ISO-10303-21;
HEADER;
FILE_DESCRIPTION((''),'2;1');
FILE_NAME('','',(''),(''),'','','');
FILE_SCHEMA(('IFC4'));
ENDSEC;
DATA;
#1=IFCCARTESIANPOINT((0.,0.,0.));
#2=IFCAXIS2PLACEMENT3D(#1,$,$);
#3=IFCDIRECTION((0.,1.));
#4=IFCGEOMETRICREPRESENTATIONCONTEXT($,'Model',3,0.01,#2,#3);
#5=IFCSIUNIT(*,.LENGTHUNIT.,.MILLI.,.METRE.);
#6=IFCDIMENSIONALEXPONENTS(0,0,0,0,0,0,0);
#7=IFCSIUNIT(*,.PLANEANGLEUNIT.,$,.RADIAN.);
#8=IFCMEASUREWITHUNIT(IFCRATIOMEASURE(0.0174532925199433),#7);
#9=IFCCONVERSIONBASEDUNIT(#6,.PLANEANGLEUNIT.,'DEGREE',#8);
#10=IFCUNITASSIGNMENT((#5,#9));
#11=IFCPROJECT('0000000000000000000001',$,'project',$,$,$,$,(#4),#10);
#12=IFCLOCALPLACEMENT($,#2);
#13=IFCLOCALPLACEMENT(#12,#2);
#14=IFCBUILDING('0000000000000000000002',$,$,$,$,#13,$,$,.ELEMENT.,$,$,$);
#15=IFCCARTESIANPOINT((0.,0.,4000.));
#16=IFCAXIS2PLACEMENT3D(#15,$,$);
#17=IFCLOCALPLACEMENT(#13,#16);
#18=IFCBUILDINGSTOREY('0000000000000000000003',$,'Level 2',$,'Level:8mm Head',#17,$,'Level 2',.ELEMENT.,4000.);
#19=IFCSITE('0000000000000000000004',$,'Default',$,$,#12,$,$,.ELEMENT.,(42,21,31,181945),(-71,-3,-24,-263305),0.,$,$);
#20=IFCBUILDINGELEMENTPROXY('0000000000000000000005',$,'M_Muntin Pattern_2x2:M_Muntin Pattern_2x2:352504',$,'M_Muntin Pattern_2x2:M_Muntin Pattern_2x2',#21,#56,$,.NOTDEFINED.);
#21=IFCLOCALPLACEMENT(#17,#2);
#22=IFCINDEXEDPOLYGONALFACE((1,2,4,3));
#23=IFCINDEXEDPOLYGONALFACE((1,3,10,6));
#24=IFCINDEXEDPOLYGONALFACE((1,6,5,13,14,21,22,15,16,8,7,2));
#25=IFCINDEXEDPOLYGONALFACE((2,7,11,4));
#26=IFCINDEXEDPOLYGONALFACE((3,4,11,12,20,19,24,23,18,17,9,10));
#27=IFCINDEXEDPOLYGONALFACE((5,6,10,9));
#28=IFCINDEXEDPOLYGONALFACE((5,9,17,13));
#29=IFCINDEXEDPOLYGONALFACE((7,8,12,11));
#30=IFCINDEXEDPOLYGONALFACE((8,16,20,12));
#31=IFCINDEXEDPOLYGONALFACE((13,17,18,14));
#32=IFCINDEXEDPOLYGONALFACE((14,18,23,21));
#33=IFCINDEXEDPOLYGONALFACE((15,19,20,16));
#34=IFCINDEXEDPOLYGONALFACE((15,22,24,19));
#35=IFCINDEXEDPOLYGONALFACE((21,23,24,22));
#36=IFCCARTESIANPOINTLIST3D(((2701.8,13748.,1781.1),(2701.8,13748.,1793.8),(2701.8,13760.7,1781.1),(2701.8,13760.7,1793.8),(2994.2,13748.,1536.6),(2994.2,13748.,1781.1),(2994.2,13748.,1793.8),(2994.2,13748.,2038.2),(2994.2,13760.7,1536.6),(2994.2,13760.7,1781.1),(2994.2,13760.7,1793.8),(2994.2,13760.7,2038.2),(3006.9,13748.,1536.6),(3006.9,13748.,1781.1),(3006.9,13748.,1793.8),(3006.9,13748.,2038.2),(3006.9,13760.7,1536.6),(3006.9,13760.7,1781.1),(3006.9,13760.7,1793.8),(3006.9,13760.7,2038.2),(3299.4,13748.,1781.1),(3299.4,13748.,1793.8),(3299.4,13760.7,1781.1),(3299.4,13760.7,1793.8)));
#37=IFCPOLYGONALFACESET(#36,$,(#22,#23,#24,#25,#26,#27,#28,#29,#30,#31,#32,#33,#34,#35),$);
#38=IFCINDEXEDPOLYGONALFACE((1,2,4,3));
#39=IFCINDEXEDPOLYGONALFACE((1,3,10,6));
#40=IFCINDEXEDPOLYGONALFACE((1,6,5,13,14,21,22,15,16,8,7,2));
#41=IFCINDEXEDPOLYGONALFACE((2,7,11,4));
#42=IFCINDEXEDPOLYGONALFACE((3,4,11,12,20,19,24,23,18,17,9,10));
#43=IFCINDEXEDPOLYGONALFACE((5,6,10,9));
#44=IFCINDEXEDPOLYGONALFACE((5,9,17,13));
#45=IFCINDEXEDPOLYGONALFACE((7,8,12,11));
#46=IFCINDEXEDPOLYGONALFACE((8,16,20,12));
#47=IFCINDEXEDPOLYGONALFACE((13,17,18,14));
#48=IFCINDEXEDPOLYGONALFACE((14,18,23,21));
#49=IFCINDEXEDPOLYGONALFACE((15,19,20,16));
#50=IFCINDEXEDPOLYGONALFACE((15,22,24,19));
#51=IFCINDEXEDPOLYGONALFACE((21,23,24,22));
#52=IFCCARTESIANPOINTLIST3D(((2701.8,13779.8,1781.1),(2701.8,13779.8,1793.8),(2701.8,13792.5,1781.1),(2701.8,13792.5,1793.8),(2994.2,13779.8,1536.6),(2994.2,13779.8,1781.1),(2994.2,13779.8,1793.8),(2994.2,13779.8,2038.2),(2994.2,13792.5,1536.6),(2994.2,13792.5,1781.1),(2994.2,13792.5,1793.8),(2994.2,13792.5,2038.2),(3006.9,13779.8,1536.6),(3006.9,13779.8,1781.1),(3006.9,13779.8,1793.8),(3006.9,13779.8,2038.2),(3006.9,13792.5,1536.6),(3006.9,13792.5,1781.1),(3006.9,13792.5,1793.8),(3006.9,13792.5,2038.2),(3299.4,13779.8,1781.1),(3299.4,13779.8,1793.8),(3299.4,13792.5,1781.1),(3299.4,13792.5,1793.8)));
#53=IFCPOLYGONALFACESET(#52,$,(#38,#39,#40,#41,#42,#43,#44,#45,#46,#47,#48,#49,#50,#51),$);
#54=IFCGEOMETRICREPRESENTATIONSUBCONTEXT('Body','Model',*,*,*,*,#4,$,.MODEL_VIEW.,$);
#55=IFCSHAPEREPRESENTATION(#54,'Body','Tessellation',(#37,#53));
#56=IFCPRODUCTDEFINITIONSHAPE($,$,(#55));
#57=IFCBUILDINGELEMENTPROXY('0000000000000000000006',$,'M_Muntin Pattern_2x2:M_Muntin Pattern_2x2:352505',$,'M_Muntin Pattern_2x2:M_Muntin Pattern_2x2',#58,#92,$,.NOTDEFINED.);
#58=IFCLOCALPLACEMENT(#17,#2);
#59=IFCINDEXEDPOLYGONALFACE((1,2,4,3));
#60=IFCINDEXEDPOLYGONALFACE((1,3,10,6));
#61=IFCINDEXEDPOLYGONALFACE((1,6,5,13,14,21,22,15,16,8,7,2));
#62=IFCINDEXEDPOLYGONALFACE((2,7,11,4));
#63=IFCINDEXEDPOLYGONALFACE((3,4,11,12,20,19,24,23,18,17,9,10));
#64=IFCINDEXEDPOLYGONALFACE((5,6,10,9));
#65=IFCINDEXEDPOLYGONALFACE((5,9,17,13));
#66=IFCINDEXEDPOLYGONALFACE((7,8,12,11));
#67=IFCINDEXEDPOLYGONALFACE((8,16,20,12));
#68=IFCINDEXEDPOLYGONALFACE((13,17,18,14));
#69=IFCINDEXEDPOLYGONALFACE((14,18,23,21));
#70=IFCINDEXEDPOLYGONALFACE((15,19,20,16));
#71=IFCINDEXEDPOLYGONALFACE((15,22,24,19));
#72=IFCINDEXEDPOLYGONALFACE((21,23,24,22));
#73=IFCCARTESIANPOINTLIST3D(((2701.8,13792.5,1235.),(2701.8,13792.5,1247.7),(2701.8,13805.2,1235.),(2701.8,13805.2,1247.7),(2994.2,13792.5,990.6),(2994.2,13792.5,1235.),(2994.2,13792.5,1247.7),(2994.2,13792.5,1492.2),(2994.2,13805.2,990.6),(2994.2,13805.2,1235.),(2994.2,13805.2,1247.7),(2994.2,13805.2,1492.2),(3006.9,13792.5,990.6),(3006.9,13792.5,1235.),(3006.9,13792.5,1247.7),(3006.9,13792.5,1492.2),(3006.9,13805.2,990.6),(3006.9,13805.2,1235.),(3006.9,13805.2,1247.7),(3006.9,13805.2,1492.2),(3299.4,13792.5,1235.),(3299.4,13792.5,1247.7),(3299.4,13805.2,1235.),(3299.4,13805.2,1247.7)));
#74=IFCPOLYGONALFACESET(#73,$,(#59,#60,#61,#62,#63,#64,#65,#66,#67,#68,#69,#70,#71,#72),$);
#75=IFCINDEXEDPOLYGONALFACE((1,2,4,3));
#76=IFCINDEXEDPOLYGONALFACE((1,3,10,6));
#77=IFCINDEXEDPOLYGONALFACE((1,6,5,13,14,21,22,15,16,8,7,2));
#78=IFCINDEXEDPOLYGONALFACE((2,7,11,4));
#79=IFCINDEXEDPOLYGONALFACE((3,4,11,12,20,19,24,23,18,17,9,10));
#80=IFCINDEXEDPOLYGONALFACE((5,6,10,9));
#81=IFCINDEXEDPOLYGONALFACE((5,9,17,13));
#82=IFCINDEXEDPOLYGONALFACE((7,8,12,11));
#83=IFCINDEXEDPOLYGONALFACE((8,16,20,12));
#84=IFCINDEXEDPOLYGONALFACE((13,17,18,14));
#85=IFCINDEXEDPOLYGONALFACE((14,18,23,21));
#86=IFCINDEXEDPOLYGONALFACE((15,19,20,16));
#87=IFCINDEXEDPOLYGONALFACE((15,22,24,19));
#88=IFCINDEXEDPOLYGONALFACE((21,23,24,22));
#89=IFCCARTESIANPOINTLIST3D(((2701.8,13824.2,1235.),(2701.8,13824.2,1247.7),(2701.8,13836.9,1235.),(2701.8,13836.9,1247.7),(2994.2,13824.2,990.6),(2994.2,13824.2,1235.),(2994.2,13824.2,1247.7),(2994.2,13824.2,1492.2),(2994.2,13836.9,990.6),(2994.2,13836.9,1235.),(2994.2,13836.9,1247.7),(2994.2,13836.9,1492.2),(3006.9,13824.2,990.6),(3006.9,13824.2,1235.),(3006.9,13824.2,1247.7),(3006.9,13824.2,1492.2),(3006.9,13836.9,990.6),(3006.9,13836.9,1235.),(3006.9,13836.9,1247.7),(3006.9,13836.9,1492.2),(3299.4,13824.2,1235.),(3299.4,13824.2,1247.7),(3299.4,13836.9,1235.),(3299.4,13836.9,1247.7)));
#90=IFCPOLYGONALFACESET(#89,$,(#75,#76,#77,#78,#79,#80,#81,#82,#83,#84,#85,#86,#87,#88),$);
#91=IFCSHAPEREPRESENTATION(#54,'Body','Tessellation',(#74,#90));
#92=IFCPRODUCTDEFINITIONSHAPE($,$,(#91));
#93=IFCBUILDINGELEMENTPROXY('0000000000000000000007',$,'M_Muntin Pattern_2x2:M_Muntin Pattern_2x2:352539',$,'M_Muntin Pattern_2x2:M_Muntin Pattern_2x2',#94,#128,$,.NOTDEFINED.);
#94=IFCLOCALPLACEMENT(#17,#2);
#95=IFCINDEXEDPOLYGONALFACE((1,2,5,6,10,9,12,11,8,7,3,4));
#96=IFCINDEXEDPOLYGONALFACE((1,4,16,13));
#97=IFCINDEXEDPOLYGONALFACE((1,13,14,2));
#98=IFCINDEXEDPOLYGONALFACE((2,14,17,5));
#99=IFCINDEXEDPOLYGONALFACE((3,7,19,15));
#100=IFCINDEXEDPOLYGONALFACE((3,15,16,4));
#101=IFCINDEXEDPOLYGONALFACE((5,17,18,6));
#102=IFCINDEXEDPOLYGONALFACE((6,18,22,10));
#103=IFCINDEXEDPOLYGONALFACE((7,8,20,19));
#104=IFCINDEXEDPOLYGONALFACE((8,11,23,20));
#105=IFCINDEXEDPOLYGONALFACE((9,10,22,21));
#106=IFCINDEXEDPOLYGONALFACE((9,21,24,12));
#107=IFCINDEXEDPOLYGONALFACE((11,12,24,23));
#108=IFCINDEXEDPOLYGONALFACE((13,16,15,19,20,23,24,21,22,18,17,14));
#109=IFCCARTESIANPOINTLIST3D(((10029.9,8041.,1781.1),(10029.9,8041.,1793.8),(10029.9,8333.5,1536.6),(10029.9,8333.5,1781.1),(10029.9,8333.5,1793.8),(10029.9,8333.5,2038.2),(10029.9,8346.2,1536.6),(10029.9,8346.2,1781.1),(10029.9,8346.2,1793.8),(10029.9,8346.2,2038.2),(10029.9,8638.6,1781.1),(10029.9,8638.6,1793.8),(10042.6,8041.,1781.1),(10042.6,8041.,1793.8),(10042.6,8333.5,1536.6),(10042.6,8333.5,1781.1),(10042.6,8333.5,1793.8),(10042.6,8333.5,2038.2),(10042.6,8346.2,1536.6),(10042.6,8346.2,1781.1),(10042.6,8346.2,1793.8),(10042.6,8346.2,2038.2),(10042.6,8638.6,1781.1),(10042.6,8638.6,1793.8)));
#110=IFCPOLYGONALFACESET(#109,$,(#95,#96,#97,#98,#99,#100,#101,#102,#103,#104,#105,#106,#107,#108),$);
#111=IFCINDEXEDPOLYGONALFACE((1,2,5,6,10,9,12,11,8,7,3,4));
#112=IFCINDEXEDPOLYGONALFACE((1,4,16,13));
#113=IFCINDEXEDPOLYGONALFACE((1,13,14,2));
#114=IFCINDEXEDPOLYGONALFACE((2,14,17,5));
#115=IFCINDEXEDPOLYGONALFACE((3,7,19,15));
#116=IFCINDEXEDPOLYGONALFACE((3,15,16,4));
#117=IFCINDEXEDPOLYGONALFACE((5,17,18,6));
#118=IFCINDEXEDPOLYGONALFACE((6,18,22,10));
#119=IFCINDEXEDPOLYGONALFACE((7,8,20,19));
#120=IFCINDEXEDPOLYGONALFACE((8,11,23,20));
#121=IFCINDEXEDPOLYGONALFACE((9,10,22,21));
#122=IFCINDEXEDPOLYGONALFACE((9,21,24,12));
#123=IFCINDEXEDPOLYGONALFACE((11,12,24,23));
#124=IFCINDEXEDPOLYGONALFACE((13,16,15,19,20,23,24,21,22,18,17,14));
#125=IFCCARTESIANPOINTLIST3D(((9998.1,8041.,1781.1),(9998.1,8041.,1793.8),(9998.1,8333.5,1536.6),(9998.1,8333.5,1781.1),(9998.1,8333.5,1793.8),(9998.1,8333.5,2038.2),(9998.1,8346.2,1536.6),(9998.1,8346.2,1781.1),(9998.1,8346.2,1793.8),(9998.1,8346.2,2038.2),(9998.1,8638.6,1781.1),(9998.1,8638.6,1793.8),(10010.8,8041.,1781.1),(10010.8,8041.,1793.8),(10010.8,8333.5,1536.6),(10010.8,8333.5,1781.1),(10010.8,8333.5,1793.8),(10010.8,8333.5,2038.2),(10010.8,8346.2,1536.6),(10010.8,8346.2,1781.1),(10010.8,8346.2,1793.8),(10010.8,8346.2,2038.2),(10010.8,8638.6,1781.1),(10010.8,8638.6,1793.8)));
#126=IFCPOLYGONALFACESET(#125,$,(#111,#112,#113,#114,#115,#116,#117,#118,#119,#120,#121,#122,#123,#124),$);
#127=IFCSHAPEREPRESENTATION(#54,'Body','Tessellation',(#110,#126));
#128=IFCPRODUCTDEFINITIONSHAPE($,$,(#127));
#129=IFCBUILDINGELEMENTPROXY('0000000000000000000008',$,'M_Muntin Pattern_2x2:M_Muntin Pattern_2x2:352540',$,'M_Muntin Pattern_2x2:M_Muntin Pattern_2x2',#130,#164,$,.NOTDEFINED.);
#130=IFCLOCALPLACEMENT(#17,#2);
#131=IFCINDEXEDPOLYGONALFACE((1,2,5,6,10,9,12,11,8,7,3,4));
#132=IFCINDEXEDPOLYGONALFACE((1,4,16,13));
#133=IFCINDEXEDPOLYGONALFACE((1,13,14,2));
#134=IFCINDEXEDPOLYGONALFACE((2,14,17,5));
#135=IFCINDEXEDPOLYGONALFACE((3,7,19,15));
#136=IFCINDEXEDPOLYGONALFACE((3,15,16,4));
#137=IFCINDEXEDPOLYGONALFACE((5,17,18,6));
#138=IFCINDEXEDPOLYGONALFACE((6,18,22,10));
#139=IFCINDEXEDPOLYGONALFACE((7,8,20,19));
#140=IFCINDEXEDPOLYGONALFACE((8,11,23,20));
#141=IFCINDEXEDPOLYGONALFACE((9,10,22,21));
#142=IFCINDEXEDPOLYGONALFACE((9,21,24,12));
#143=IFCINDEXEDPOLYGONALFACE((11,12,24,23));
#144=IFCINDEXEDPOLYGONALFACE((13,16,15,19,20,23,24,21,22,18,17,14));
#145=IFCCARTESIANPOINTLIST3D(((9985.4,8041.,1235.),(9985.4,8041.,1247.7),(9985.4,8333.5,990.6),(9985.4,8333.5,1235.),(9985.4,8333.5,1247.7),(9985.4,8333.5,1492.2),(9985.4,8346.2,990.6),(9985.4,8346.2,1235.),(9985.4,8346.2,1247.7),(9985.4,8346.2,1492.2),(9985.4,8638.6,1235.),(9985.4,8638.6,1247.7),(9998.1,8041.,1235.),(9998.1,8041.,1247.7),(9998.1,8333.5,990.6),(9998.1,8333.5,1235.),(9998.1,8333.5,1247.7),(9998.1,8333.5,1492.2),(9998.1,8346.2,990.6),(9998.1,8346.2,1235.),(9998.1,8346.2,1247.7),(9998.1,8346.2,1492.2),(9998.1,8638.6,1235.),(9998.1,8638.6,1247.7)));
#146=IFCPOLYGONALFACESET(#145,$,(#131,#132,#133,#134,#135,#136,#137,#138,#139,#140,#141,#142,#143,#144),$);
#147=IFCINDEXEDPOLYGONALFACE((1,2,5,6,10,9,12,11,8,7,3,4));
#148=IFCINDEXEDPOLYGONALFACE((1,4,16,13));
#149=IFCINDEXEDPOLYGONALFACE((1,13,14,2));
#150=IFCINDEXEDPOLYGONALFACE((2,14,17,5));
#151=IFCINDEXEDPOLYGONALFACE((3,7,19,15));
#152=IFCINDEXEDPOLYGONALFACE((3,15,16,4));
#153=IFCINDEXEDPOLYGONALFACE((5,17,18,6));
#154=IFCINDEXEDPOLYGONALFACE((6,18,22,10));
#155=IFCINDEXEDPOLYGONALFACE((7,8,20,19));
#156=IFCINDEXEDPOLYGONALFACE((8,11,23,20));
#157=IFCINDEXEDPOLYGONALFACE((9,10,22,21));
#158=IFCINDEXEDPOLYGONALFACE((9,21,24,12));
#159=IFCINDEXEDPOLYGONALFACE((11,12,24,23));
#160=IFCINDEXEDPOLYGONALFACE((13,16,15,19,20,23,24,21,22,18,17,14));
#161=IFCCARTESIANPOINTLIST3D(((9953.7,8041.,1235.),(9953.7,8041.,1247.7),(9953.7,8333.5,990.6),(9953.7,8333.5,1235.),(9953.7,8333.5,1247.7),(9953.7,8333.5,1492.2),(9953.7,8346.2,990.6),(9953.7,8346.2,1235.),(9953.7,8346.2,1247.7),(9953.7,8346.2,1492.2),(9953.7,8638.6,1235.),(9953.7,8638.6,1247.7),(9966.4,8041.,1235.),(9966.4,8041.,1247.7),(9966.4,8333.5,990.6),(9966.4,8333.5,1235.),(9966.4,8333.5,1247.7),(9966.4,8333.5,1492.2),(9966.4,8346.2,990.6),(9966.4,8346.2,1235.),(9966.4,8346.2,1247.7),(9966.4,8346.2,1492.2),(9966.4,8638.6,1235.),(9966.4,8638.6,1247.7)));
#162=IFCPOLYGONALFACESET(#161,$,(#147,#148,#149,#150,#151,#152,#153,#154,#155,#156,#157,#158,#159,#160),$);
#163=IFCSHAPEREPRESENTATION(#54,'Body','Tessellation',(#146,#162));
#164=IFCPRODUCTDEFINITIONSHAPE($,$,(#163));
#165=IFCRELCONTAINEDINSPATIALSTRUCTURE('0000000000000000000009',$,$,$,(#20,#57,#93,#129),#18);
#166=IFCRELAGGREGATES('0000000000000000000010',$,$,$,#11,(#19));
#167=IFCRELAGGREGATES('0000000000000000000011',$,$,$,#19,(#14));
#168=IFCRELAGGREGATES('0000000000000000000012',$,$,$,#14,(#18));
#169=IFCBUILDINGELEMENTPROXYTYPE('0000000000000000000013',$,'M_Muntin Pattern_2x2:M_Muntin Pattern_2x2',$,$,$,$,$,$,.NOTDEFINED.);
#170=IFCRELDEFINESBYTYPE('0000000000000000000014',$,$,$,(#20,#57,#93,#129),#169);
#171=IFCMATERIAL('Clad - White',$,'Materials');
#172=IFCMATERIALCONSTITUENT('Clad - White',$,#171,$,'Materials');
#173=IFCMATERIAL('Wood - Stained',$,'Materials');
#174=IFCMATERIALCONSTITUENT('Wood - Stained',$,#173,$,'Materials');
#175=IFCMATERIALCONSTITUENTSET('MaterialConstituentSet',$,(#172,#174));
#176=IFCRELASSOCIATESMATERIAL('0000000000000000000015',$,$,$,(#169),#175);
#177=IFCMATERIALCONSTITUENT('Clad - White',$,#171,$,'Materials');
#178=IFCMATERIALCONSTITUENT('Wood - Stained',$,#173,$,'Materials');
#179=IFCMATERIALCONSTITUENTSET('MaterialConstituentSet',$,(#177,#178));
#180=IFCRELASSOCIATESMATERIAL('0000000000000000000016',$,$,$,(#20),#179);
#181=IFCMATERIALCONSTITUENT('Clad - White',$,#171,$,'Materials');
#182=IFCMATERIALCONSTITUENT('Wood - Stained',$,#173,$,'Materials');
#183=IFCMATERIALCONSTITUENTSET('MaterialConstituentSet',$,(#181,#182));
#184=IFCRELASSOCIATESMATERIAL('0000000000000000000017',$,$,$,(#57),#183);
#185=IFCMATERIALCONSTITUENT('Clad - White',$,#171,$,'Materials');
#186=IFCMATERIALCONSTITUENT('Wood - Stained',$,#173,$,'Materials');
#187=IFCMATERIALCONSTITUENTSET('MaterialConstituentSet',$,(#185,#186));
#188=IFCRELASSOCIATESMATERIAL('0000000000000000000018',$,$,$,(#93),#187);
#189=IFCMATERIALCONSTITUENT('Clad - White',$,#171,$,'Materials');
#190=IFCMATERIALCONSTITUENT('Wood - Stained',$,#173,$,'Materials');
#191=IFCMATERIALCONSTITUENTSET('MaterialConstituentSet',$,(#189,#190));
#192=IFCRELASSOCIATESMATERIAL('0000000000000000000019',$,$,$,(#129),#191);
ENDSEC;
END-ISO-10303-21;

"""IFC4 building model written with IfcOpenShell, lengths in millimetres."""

from ifc_helpers import new_model, entity, si_unit, converted_unit, direction, frame, origin, place, context, subcontext, project, spatial, polyline, outline, extrude, source, transform, mapped, material, constituent, constituent_set, type_object, type_shapes, element, save


model = new_model("IFC4")

# Units and contexts
model_context = context("Model", 3, precision=0.01, world=origin(), true_north=direction((0.0, 1.0)))
body_context = subcontext(model_context, "Body", "Model", "MODEL_VIEW")
ifc_project = project(units=[si_unit("LENGTHUNIT", "METRE", prefix="MILLI"), converted_unit("PLANEANGLEUNIT", "DEGREE", entity("IfcRatioMeasure", 0.0174532925199433), si_unit("PLANEANGLEUNIT", "RADIAN"), dimensions=[0, 0, 0, 0, 0, 0, 0])], contexts=[model_context])

# Site, building, storey
site_placement = place(None, origin())
site = spatial("IfcSite", under=ifc_project, at=site_placement, Name="Default", CompositionType="ELEMENT", RefLatitude=(42, 21, 31, 181945), RefLongitude=(-71, -3, -24, -263305), RefElevation=0.0)
building_placement = place(site_placement, origin())
building = spatial("IfcBuilding", under=site, at=building_placement, CompositionType="ELEMENT")
storey_placement = place(building_placement, frame((0.0, 0.0, 4000.0)))
storey = spatial("IfcBuildingStorey", under=building, at=storey_placement, Name="Level 2", ObjectType="Level:8mm Head", LongName="Level 2", CompositionType="ELEMENT", Elevation=4000.0)

# Shared definitions
ifc_material_1 = material(Name="Wood - Stained", Category="Materials")

# Building element proxies
ifc_material_2 = material(Name="Clad - White", Category="Materials")
ifc_constituent_1 = constituent(ifc_material_2, Name="Clad - White", Category="Materials")
ifc_constituent_2 = constituent(ifc_material_1, Name="Wood - Stained", Category="Materials")
ifc_constituent_set_1 = constituent_set(constituents=[ifc_constituent_1, ifc_constituent_2], Name="MaterialConstituentSet")
building_element_proxy_type_1 = type_object("IfcBuildingElementProxyType", Name="M_Muntin Pattern_2x2:M_Muntin Pattern_2x2", PredefinedType="NOTDEFINED", material=ifc_constituent_set_1)
shared_shape_1 = source(origin(), body_context, "Body", "SweptSolid", [
    extrude(outline(polyline([(6.4, -6.4), (250.8, -6.4), (250.8, 6.3), (6.4, 6.3), (6.4, 298.8), (-6.3, 298.8), (-6.3, 6.3), (-250.8, 6.3), (-250.8, -6.4), (-6.3, -6.4), (-6.3, -298.8), (6.4, -298.8), (6.4, -6.4)])), frame((0.0, 9.5, 250.8), z_axis=(0.0, 1.0, 0.0), x_axis=(0.0, 0.0, 1.0)), (0.0, 0.0, 1.0), 12.7),
    extrude(outline(polyline([(6.4, -6.4), (250.8, -6.4), (250.8, 6.3), (6.4, 6.3), (6.4, 298.8), (-6.3, 298.8), (-6.3, 6.3), (-250.8, 6.3), (-250.8, -6.4), (-6.3, -6.4), (-6.3, -298.8), (6.4, -298.8), (6.4, -6.4)])), frame((0.0, -22.2, 250.8), z_axis=(0.0, 1.0, 0.0), x_axis=(0.0, 0.0, 1.0)), (0.0, 0.0, 1.0), 12.7),
])
type_shapes(building_element_proxy_type_1, [shared_shape_1])
ifc_constituent_3 = constituent(ifc_material_2, Name="Clad - White", Category="Materials")
ifc_constituent_4 = constituent(ifc_material_1, Name="Wood - Stained", Category="Materials")
ifc_constituent_set_2 = constituent_set(constituents=[ifc_constituent_3, ifc_constituent_4], Name="MaterialConstituentSet")
proxy_1_placement = place(storey_placement, frame((3000.6, 13770.3, 1536.6), z_axis=(0.0, 0.0, 1.0), x_axis=(-1.0, 0.0, 0.0)))
element("IfcBuildingElementProxy", 1, at=proxy_1_placement, inside=storey, type_object=building_element_proxy_type_1, material=ifc_constituent_set_2, Name="M_Muntin Pattern_2x2:M_Muntin Pattern_2x2:352504", ObjectType="M_Muntin Pattern_2x2:M_Muntin Pattern_2x2", PredefinedType="NOTDEFINED", context=body_context, shape_type="MappedRepresentation", body=[
    mapped(shared_shape_1, transform((0.0, 0.0, 0.0), scale=1.0)),
])
ifc_constituent_5 = constituent(ifc_material_2, Name="Clad - White", Category="Materials")
ifc_constituent_6 = constituent(ifc_material_1, Name="Wood - Stained", Category="Materials")
ifc_constituent_set_3 = constituent_set(constituents=[ifc_constituent_5, ifc_constituent_6], Name="MaterialConstituentSet")
proxy_2_placement = place(storey_placement, frame((3000.6, 13814.7, 990.6), z_axis=(0.0, 0.0, 1.0), x_axis=(-1.0, 0.0, 0.0)))
element("IfcBuildingElementProxy", 2, at=proxy_2_placement, inside=storey, type_object=building_element_proxy_type_1, material=ifc_constituent_set_3, Name="M_Muntin Pattern_2x2:M_Muntin Pattern_2x2:352505", ObjectType="M_Muntin Pattern_2x2:M_Muntin Pattern_2x2", PredefinedType="NOTDEFINED", context=body_context, shape_type="MappedRepresentation", body=[
    mapped(shared_shape_1, transform((0.0, 0.0, 0.0), scale=1.0)),
])
ifc_constituent_7 = constituent(ifc_material_2, Name="Clad - White", Category="Materials")
ifc_constituent_8 = constituent(ifc_material_1, Name="Wood - Stained", Category="Materials")
ifc_constituent_set_4 = constituent_set(constituents=[ifc_constituent_7, ifc_constituent_8], Name="MaterialConstituentSet")
proxy_3_placement = place(storey_placement, frame((10020.3, 8339.8, 1536.6), z_axis=(0.0, 0.0, 1.0), x_axis=(0.0, -1.0, 0.0)))
element("IfcBuildingElementProxy", 3, at=proxy_3_placement, inside=storey, type_object=building_element_proxy_type_1, material=ifc_constituent_set_4, Name="M_Muntin Pattern_2x2:M_Muntin Pattern_2x2:352539", ObjectType="M_Muntin Pattern_2x2:M_Muntin Pattern_2x2", PredefinedType="NOTDEFINED", context=body_context, shape_type="MappedRepresentation", body=[
    mapped(shared_shape_1, transform((0.0, 0.0, 0.0), scale=1.0)),
])
ifc_constituent_9 = constituent(ifc_material_2, Name="Clad - White", Category="Materials")
ifc_constituent_10 = constituent(ifc_material_1, Name="Wood - Stained", Category="Materials")
ifc_constituent_set_5 = constituent_set(constituents=[ifc_constituent_9, ifc_constituent_10], Name="MaterialConstituentSet")
proxy_4_placement = place(storey_placement, frame((9975.9, 8339.8, 990.6), z_axis=(0.0, 0.0, 1.0), x_axis=(0.0, -1.0, 0.0)))
element("IfcBuildingElementProxy", 4, at=proxy_4_placement, inside=storey, type_object=building_element_proxy_type_1, material=ifc_constituent_set_5, Name="M_Muntin Pattern_2x2:M_Muntin Pattern_2x2:352540", ObjectType="M_Muntin Pattern_2x2:M_Muntin Pattern_2x2", PredefinedType="NOTDEFINED", context=body_context, shape_type="MappedRepresentation", body=[
    mapped(shared_shape_1, transform((0.0, 0.0, 0.0), scale=1.0)),
])

save(model, "model.ifc")
